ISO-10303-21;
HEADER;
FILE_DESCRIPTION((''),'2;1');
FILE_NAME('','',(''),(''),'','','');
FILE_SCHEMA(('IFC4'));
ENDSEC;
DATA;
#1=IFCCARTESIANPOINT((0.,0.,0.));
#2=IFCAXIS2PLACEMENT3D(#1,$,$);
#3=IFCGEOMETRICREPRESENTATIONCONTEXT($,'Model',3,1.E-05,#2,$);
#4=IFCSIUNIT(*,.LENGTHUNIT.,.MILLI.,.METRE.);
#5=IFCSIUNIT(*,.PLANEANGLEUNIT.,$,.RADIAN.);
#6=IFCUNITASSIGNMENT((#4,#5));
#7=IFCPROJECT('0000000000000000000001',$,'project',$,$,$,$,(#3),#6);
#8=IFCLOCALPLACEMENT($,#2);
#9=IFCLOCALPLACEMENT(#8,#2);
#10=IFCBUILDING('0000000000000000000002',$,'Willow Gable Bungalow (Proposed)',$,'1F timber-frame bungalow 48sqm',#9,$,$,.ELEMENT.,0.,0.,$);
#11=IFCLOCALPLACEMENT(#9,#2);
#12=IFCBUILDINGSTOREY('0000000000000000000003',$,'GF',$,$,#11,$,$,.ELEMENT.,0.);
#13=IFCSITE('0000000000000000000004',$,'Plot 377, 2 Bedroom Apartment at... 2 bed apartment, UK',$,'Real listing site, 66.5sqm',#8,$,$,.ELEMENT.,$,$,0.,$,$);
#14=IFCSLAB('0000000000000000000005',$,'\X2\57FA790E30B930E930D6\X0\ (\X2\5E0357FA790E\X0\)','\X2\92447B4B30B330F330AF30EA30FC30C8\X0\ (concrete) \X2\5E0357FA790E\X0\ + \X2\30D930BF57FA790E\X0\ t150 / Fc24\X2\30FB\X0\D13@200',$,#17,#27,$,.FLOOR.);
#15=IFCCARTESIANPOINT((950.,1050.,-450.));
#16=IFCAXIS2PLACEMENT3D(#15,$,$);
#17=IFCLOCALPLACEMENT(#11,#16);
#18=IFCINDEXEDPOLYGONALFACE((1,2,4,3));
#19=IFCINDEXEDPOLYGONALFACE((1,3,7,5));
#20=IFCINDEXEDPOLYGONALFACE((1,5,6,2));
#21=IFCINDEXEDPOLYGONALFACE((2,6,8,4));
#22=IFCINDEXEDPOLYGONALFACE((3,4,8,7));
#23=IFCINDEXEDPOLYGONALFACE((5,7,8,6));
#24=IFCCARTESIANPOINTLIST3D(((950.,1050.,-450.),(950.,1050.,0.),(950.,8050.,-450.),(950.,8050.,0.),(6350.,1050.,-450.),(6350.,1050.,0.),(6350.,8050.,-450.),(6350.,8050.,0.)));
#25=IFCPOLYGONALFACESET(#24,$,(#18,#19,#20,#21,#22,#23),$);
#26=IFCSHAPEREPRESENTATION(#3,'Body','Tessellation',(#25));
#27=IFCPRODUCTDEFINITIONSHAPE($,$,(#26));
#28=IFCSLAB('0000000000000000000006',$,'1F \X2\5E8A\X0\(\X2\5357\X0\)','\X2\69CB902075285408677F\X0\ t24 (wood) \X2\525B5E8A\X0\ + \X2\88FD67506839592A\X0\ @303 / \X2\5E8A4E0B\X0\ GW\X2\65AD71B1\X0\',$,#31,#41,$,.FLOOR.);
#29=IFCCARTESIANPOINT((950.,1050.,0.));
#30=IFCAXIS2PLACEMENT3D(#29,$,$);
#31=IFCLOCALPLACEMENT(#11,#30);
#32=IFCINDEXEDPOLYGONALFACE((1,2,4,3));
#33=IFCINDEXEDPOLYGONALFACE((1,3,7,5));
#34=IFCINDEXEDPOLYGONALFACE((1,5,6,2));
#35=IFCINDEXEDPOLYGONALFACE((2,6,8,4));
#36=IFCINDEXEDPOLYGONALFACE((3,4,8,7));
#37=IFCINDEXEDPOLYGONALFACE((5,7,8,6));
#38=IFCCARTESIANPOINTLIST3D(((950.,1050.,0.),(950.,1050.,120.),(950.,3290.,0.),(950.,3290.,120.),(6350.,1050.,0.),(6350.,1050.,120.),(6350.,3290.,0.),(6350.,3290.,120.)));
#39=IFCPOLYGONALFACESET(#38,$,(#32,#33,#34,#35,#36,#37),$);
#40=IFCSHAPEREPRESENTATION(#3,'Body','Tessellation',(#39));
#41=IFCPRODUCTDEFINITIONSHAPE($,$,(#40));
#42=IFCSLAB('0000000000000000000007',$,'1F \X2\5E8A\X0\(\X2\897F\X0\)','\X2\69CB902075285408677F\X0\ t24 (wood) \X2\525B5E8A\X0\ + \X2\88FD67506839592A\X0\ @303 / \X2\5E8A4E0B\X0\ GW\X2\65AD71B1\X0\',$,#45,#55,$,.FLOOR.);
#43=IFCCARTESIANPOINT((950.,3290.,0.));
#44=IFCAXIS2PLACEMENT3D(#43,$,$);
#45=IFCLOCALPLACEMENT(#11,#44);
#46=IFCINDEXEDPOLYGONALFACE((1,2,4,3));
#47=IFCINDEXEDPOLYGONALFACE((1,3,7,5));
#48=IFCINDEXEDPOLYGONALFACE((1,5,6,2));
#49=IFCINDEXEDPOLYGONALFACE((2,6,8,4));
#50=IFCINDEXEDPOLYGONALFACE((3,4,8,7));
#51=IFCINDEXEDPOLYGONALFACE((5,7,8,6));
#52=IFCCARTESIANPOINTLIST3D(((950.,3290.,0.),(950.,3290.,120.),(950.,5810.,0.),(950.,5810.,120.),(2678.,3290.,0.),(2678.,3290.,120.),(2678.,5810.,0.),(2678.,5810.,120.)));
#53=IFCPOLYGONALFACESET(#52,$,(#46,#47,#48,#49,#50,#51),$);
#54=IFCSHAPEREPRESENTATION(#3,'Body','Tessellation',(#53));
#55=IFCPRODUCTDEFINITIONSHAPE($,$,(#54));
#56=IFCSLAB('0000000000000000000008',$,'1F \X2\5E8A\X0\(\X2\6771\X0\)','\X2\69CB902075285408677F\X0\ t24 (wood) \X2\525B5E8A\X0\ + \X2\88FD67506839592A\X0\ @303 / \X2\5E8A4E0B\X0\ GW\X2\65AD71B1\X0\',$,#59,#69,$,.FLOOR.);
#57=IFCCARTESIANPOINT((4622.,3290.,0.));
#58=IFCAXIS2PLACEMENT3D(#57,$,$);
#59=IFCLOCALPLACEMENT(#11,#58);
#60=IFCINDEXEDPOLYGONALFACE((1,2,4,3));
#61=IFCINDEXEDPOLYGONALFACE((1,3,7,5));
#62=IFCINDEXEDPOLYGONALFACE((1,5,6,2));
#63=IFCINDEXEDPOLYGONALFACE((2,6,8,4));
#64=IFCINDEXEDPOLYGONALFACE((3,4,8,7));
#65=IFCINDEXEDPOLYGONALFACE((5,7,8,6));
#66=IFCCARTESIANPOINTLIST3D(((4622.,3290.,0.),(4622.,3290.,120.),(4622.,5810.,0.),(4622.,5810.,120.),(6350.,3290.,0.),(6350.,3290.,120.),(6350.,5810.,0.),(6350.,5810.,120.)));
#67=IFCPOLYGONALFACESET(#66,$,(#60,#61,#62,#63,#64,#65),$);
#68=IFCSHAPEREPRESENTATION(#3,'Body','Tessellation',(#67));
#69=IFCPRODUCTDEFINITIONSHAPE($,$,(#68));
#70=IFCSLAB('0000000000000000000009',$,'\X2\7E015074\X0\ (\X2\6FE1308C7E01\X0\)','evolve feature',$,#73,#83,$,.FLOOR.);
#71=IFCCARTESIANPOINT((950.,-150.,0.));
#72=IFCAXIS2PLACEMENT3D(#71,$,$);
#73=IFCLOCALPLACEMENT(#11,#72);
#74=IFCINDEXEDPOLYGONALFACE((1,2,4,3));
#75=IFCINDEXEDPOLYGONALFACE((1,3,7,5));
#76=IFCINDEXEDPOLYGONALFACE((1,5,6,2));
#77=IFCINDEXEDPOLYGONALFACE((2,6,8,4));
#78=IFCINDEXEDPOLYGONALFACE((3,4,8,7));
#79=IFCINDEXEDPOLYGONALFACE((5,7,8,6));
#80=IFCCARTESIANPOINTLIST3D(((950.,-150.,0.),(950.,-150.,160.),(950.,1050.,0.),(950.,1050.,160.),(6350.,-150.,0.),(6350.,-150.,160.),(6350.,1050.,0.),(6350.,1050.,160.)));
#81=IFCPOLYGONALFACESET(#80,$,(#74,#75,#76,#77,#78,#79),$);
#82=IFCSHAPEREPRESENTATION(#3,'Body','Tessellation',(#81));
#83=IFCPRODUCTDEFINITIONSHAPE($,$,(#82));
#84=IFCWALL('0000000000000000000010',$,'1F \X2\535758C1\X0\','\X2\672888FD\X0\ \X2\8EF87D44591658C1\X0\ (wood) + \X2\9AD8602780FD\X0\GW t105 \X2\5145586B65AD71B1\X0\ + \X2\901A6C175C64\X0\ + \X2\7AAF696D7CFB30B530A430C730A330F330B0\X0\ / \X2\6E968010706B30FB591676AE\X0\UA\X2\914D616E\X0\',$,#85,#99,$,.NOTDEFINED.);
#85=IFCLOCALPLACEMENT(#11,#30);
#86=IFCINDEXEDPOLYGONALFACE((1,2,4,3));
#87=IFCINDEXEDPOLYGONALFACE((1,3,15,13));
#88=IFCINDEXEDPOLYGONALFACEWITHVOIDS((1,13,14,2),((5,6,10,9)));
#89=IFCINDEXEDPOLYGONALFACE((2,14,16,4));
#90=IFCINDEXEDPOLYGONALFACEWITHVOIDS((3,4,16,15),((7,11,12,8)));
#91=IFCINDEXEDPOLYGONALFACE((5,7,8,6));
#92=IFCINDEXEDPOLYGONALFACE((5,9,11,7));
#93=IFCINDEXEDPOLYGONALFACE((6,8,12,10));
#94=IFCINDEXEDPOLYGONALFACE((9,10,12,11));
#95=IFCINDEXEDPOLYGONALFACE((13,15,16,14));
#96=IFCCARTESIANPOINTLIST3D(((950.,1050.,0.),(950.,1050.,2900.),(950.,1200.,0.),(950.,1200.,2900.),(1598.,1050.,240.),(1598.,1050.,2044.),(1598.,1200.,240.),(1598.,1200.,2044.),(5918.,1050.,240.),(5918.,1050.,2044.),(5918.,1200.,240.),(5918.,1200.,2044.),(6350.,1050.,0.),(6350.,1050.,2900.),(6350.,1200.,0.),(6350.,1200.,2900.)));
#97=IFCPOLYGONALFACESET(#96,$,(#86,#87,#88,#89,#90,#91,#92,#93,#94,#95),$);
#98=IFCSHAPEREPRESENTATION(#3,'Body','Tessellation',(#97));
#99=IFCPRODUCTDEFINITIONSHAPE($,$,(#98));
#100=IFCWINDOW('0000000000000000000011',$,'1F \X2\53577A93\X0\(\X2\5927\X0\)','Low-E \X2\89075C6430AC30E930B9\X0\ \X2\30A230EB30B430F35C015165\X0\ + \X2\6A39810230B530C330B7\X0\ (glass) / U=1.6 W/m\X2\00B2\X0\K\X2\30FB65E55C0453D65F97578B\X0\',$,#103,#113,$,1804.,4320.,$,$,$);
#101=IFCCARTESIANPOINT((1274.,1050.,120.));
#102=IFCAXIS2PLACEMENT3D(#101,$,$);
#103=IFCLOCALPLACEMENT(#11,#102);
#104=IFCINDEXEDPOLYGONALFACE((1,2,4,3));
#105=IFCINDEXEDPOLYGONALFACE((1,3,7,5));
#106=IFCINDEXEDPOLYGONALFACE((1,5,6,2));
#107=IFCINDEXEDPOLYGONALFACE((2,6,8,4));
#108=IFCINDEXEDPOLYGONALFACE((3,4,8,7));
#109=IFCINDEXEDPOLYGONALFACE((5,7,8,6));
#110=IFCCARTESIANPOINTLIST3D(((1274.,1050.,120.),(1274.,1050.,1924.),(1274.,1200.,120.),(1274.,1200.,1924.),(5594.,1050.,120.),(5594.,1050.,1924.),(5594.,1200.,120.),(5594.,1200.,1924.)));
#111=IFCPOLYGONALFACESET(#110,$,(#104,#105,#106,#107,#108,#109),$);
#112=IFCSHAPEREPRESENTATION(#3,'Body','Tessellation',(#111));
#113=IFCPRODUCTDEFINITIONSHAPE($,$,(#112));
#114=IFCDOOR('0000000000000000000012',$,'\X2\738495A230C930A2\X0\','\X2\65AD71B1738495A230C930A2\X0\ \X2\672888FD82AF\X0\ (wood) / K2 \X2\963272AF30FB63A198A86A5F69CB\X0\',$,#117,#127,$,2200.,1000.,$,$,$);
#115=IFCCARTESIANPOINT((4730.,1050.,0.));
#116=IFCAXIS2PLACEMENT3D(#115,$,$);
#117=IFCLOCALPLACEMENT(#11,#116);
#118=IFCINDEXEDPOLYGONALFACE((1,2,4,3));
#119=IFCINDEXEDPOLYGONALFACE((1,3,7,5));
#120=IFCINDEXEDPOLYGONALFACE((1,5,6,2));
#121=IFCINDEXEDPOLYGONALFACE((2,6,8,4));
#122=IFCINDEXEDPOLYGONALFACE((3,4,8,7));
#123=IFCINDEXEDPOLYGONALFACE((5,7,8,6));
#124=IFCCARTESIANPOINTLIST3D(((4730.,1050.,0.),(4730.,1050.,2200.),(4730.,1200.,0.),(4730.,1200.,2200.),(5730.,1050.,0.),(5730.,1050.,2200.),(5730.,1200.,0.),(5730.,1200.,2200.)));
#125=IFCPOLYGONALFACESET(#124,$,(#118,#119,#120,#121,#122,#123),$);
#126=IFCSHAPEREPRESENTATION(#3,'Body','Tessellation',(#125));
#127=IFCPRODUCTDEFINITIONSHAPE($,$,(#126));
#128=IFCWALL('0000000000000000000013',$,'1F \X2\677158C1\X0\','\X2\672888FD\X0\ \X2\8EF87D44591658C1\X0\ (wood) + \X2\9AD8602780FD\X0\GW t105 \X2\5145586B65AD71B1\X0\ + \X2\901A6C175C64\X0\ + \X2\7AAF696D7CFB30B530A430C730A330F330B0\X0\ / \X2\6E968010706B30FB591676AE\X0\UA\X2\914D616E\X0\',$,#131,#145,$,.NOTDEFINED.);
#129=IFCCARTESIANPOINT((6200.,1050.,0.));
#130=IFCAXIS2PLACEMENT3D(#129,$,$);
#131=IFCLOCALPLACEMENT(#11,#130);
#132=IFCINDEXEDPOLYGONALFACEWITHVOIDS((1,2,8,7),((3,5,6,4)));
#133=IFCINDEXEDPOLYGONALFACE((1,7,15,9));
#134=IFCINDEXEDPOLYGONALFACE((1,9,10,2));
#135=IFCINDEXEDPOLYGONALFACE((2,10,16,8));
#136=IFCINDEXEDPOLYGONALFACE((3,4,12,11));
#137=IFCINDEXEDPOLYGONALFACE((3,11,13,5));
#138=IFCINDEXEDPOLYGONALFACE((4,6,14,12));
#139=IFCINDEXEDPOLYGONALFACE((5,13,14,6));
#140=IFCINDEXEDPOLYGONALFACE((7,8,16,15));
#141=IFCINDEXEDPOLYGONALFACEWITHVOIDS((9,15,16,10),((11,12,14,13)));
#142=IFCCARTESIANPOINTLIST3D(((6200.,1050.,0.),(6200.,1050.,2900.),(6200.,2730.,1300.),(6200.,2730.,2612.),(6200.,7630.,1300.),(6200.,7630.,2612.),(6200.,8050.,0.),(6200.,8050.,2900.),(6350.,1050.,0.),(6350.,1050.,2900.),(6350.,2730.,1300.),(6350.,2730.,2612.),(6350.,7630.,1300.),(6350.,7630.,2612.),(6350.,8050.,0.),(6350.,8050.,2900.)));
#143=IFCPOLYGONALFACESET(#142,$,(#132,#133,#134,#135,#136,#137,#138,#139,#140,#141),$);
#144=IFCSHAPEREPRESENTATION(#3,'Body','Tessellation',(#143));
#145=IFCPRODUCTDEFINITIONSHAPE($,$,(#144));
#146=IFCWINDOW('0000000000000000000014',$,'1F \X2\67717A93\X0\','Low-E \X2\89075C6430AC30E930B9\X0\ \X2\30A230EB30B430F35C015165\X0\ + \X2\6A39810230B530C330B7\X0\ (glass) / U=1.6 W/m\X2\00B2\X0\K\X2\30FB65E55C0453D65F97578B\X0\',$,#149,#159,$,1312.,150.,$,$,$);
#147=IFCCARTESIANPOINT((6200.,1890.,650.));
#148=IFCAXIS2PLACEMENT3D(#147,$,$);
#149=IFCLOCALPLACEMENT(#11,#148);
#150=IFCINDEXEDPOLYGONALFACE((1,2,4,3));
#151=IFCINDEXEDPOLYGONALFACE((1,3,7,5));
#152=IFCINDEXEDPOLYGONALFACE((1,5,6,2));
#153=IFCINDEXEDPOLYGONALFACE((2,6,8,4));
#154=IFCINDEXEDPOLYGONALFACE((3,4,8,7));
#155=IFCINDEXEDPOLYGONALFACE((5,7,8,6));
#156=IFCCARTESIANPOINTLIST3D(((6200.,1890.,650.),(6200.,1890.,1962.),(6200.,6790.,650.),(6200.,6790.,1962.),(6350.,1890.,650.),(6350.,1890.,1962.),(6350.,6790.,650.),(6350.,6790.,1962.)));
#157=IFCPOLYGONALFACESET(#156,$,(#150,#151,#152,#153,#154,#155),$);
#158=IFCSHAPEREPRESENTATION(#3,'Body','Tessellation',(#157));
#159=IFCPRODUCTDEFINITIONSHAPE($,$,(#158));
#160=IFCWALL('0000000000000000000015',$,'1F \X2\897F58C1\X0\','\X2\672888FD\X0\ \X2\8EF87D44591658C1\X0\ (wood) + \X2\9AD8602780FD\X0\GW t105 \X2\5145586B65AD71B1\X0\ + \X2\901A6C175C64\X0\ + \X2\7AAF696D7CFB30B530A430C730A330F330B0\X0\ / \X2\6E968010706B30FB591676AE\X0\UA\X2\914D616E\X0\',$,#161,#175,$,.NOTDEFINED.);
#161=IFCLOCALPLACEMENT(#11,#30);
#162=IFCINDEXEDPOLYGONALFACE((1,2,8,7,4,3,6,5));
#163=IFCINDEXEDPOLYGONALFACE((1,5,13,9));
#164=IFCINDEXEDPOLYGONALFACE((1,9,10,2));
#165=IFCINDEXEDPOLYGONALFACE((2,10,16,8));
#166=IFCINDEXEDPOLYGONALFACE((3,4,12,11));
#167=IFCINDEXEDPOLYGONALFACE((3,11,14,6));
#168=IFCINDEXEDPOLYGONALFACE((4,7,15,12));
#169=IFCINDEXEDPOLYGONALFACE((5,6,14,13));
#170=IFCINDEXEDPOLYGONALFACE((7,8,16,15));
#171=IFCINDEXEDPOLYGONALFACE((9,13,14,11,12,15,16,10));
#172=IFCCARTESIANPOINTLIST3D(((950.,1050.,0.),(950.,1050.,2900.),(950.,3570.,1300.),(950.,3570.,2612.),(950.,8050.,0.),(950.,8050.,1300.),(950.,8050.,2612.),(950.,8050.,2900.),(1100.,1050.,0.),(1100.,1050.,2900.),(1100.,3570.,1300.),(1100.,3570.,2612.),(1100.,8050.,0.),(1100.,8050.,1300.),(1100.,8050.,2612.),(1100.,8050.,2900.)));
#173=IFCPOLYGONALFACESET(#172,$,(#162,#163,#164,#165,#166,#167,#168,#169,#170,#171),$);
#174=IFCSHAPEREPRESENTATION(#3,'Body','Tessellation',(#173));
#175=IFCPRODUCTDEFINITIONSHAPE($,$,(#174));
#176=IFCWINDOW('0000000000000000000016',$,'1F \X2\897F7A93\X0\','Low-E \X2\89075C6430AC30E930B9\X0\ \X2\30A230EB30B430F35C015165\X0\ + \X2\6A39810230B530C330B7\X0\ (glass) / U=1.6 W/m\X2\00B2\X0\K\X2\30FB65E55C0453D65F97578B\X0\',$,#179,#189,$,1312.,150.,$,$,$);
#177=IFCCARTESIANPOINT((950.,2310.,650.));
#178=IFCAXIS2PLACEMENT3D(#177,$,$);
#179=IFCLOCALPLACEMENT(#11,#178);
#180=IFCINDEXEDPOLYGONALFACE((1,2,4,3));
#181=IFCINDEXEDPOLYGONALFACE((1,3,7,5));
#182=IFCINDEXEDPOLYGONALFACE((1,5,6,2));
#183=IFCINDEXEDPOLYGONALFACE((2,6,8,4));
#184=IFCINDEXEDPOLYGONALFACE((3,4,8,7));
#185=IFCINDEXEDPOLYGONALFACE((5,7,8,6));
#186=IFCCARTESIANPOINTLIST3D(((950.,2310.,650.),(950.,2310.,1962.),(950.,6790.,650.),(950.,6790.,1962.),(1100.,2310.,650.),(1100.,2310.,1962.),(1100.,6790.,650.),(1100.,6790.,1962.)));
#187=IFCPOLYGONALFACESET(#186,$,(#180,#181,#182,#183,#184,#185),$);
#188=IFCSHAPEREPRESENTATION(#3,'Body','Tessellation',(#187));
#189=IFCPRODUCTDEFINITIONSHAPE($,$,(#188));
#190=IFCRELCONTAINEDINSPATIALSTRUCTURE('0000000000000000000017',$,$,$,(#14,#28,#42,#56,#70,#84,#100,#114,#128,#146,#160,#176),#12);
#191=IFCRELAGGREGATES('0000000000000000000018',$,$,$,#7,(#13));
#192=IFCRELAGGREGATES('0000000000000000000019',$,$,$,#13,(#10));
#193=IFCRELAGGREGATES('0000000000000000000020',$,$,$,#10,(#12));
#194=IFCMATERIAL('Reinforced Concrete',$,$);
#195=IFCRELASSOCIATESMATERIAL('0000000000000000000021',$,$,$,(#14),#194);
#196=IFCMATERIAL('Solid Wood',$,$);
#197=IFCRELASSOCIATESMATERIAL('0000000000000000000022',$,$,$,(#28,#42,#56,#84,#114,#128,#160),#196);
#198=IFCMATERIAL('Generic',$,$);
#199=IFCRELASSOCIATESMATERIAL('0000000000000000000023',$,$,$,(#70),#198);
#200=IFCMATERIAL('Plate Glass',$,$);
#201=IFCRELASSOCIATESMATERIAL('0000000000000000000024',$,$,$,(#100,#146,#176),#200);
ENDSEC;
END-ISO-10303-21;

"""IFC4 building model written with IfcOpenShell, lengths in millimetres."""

from ifc_helpers import new_model, si_unit, frame, frame_2d, origin, place, context, project, spatial, rectangle, extrude, material, element, fill, save


model = new_model("IFC4")

# Units and contexts
model_context = context("Model", 3, precision=1e-05, world=origin())
ifc_project = project(units=[si_unit("LENGTHUNIT", "METRE", prefix="MILLI"), si_unit("PLANEANGLEUNIT", "RADIAN")], contexts=[model_context])

# Site, building, storey
site_placement = place(None, origin())
site = spatial("IfcSite", under=ifc_project, at=site_placement, Name="Plot 377, 2 Bedroom Apartment at... 2 bed apartment, UK", ObjectType="Real listing site, 66.5sqm", CompositionType="ELEMENT", RefElevation=0.0)
building_placement = place(site_placement, origin())
building = spatial("IfcBuilding", under=site, at=building_placement, Name="Willow Gable Bungalow (Proposed)", ObjectType="1F timber-frame bungalow 48sqm", CompositionType="ELEMENT", ElevationOfRefHeight=0.0, ElevationOfTerrain=0.0)
storey_placement = place(building_placement, origin())
storey = spatial("IfcBuildingStorey", under=building, at=storey_placement, Name="GF", CompositionType="ELEMENT", Elevation=0.0)

# Slabs
ifc_material_1 = material(Name="Reinforced Concrete")
slab_1_placement = place(storey_placement, frame((950.0, 1050.0, -450.0)))
element("IfcSlab", 1, at=slab_1_placement, inside=storey, material=ifc_material_1, Name="基礎スラブ (布基礎)", Description="鉄筋コンクリート (concrete) 布基礎 + ベタ基礎 t150 / Fc24・D13@200", PredefinedType="FLOOR", context=model_context, shape_type="SweptSolid", body=[
    extrude(rectangle(XDim=5400.0, YDim=7000.0, at=frame_2d((2700.0, 3500.0))), frame((950.0, 1050.0, -450.0)), (0.0, 0.0, 1.0), 450.0),
])
ifc_material_2 = material(Name="Solid Wood")
slab_2_placement = place(storey_placement, frame((950.0, 1050.0, 0.0)))
element("IfcSlab", 2, at=slab_2_placement, inside=storey, material=ifc_material_2, Name="1F 床(南)", Description="構造用合板 t24 (wood) 剛床 + 製材根太 @303 / 床下 GW断熱", PredefinedType="FLOOR", context=model_context, shape_type="SweptSolid", body=[
    extrude(rectangle(XDim=5400.0, YDim=2240.0, at=frame_2d((2700.0, 1120.0))), frame((950.0, 1050.0, 0.0)), (0.0, 0.0, 1.0), 120.0),
])
slab_3_placement = place(storey_placement, frame((950.0, 3290.0, 0.0)))
element("IfcSlab", 3, at=slab_3_placement, inside=storey, material=ifc_material_2, Name="1F 床(西)", Description="構造用合板 t24 (wood) 剛床 + 製材根太 @303 / 床下 GW断熱", PredefinedType="FLOOR", context=model_context, shape_type="SweptSolid", body=[
    extrude(rectangle(XDim=1728.0, YDim=2520.0, at=frame_2d((864.0, 1260.0))), frame((950.0, 3290.0, 0.0)), (0.0, 0.0, 1.0), 120.0),
])
slab_4_placement = place(storey_placement, frame((4622.0, 3290.0, 0.0)))
element("IfcSlab", 4, at=slab_4_placement, inside=storey, material=ifc_material_2, Name="1F 床(東)", Description="構造用合板 t24 (wood) 剛床 + 製材根太 @303 / 床下 GW断熱", PredefinedType="FLOOR", context=model_context, shape_type="SweptSolid", body=[
    extrude(rectangle(XDim=1728.0, YDim=2520.0, at=frame_2d((864.0, 1260.0))), frame((4622.0, 3290.0, 0.0)), (0.0, 0.0, 1.0), 120.0),
])
ifc_material_3 = material(Name="Generic")
slab_5_placement = place(storey_placement, frame((950.0, -150.0, 0.0)))
element("IfcSlab", 5, at=slab_5_placement, inside=storey, material=ifc_material_3, Name="縁側 (濡れ縁)", Description="evolve feature", PredefinedType="FLOOR", context=model_context, shape_type="SweptSolid", body=[
    extrude(rectangle(XDim=5400.0, YDim=1200.0, at=frame_2d((2700.0, 600.0))), frame((950.0, -150.0, 0.0)), (0.0, 0.0, 1.0), 160.0),
])

# Wall, openings, window, door
wall_1_placement = place(storey_placement, frame((950.0, 1050.0, 0.0)))
wall_1 = element("IfcWall", 6, at=wall_1_placement, inside=storey, material=ifc_material_2, Name="1F 南壁", Description="木製 軸組外壁 (wood) + 高性能GW t105 充填断熱 + 通気層 + 窯業系サイディング / 準耐火・外皮UA配慮", PredefinedType="NOTDEFINED", context=model_context, shape_type="SweptSolid", body=[
    extrude(rectangle(XDim=5400.0, YDim=150.0, at=frame_2d((2700.0, 75.0))), frame((950.0, 1050.0, 0.0)), (0.0, 0.0, 1.0), 2900.0),
])
opening_1_placement = place(storey_placement, frame((1274.0, 1050.0, 120.0)))
opening_1 = element("IfcOpeningElement", 7, at=opening_1_placement, cuts=wall_1, PredefinedType="NOTDEFINED", context=model_context, shape_type="SweptSolid", body=[
    extrude(rectangle(XDim=4320.0, YDim=150.0, at=frame_2d((2160.0, 75.0))), frame((1274.0, 1050.0, 120.0)), (0.0, 0.0, 1.0), 1804.0),
])
opening_2_placement = place(storey_placement, frame((4730.0, 1050.0, 0.0)))
opening_2 = element("IfcOpeningElement", 8, at=opening_2_placement, cuts=wall_1, PredefinedType="NOTDEFINED", context=model_context, shape_type="SweptSolid", body=[
    extrude(rectangle(XDim=1000.0, YDim=150.0, at=frame_2d((500.0, 75.0))), frame((4730.0, 1050.0, 0.0)), (0.0, 0.0, 1.0), 2200.0),
])
ifc_material_4 = material(Name="Plate Glass")
window_1_placement = place(storey_placement, frame((1274.0, 1050.0, 120.0)))
window_1 = element("IfcWindow", 9, at=window_1_placement, inside=storey, material=ifc_material_4, Name="1F 南窓(大)", Description="Low-E 複層ガラス アルゴン封入 + 樹脂サッシ (glass) / U=1.6 W/m²K・日射取得型", OverallHeight=1804.0, OverallWidth=4320.0, context=model_context, shape_type="SweptSolid", body=[
    extrude(rectangle(XDim=4320.0, YDim=150.0, at=frame_2d((2160.0, 75.0))), frame((1274.0, 1050.0, 120.0)), (0.0, 0.0, 1.0), 1804.0),
])
fill(opening_1, window_1)
door_placement = place(storey_placement, frame((4730.0, 1050.0, 0.0)))
door = element("IfcDoor", 10, at=door_placement, inside=storey, material=ifc_material_2, Name="玄関ドア", Description="断熱玄関ドア 木製芯 (wood) / K2 防犯・採風機構", OverallHeight=2200.0, OverallWidth=1000.0, context=model_context, shape_type="SweptSolid", body=[
    extrude(rectangle(XDim=1000.0, YDim=150.0, at=frame_2d((500.0, 75.0))), frame((4730.0, 1050.0, 0.0)), (0.0, 0.0, 1.0), 2200.0),
])
fill(opening_2, door)

# Walls, openings, windows
wall_2_placement = place(storey_placement, frame((6200.0, 1050.0, 0.0)))
wall_2 = element("IfcWall", 11, at=wall_2_placement, inside=storey, material=ifc_material_2, Name="1F 東壁", Description="木製 軸組外壁 (wood) + 高性能GW t105 充填断熱 + 通気層 + 窯業系サイディング / 準耐火・外皮UA配慮", PredefinedType="NOTDEFINED", context=model_context, shape_type="SweptSolid", body=[
    extrude(rectangle(XDim=150.0, YDim=7000.0, at=frame_2d((75.0, 3500.0))), frame((6200.0, 1050.0, 0.0)), (0.0, 0.0, 1.0), 2900.0),
])
opening_3_placement = place(storey_placement, frame((6200.0, 1890.0, 650.0)))
opening_3 = element("IfcOpeningElement", 12, at=opening_3_placement, cuts=wall_2, PredefinedType="NOTDEFINED", context=model_context, shape_type="SweptSolid", body=[
    extrude(rectangle(XDim=150.0, YDim=4900.0, at=frame_2d((75.0, 2450.0))), frame((6200.0, 1890.0, 650.0)), (0.0, 0.0, 1.0), 1312.0),
])
window_2_placement = place(storey_placement, frame((6200.0, 1890.0, 650.0)))
window_2 = element("IfcWindow", 13, at=window_2_placement, inside=storey, material=ifc_material_4, Name="1F 東窓", Description="Low-E 複層ガラス アルゴン封入 + 樹脂サッシ (glass) / U=1.6 W/m²K・日射取得型", OverallHeight=1312.0, OverallWidth=150.0, context=model_context, shape_type="SweptSolid", body=[
    extrude(rectangle(XDim=150.0, YDim=4900.0, at=frame_2d((75.0, 2450.0))), frame((6200.0, 1890.0, 650.0)), (0.0, 0.0, 1.0), 1312.0),
])
fill(opening_3, window_2)
wall_3_placement = place(storey_placement, frame((950.0, 1050.0, 0.0)))
wall_3 = element("IfcWall", 14, at=wall_3_placement, inside=storey, material=ifc_material_2, Name="1F 西壁", Description="木製 軸組外壁 (wood) + 高性能GW t105 充填断熱 + 通気層 + 窯業系サイディング / 準耐火・外皮UA配慮", PredefinedType="NOTDEFINED", context=model_context, shape_type="SweptSolid", body=[
    extrude(rectangle(XDim=150.0, YDim=7000.0, at=frame_2d((75.0, 3500.0))), frame((950.0, 1050.0, 0.0)), (0.0, 0.0, 1.0), 2900.0),
])
opening_4_placement = place(storey_placement, frame((950.0, 2310.0, 650.0)))
opening_4 = element("IfcOpeningElement", 15, at=opening_4_placement, cuts=wall_3, PredefinedType="NOTDEFINED", context=model_context, shape_type="SweptSolid", body=[
    extrude(rectangle(XDim=150.0, YDim=4480.0, at=frame_2d((75.0, 2240.0))), frame((950.0, 2310.0, 650.0)), (0.0, 0.0, 1.0), 1312.0),
])
window_3_placement = place(storey_placement, frame((950.0, 2310.0, 650.0)))
window_3 = element("IfcWindow", 16, at=window_3_placement, inside=storey, material=ifc_material_4, Name="1F 西窓", Description="Low-E 複層ガラス アルゴン封入 + 樹脂サッシ (glass) / U=1.6 W/m²K・日射取得型", OverallHeight=1312.0, OverallWidth=150.0, context=model_context, shape_type="SweptSolid", body=[
    extrude(rectangle(XDim=150.0, YDim=4480.0, at=frame_2d((75.0, 2240.0))), frame((950.0, 2310.0, 650.0)), (0.0, 0.0, 1.0), 1312.0),
])
fill(opening_4, window_3)

save(model, "model.ifc")
